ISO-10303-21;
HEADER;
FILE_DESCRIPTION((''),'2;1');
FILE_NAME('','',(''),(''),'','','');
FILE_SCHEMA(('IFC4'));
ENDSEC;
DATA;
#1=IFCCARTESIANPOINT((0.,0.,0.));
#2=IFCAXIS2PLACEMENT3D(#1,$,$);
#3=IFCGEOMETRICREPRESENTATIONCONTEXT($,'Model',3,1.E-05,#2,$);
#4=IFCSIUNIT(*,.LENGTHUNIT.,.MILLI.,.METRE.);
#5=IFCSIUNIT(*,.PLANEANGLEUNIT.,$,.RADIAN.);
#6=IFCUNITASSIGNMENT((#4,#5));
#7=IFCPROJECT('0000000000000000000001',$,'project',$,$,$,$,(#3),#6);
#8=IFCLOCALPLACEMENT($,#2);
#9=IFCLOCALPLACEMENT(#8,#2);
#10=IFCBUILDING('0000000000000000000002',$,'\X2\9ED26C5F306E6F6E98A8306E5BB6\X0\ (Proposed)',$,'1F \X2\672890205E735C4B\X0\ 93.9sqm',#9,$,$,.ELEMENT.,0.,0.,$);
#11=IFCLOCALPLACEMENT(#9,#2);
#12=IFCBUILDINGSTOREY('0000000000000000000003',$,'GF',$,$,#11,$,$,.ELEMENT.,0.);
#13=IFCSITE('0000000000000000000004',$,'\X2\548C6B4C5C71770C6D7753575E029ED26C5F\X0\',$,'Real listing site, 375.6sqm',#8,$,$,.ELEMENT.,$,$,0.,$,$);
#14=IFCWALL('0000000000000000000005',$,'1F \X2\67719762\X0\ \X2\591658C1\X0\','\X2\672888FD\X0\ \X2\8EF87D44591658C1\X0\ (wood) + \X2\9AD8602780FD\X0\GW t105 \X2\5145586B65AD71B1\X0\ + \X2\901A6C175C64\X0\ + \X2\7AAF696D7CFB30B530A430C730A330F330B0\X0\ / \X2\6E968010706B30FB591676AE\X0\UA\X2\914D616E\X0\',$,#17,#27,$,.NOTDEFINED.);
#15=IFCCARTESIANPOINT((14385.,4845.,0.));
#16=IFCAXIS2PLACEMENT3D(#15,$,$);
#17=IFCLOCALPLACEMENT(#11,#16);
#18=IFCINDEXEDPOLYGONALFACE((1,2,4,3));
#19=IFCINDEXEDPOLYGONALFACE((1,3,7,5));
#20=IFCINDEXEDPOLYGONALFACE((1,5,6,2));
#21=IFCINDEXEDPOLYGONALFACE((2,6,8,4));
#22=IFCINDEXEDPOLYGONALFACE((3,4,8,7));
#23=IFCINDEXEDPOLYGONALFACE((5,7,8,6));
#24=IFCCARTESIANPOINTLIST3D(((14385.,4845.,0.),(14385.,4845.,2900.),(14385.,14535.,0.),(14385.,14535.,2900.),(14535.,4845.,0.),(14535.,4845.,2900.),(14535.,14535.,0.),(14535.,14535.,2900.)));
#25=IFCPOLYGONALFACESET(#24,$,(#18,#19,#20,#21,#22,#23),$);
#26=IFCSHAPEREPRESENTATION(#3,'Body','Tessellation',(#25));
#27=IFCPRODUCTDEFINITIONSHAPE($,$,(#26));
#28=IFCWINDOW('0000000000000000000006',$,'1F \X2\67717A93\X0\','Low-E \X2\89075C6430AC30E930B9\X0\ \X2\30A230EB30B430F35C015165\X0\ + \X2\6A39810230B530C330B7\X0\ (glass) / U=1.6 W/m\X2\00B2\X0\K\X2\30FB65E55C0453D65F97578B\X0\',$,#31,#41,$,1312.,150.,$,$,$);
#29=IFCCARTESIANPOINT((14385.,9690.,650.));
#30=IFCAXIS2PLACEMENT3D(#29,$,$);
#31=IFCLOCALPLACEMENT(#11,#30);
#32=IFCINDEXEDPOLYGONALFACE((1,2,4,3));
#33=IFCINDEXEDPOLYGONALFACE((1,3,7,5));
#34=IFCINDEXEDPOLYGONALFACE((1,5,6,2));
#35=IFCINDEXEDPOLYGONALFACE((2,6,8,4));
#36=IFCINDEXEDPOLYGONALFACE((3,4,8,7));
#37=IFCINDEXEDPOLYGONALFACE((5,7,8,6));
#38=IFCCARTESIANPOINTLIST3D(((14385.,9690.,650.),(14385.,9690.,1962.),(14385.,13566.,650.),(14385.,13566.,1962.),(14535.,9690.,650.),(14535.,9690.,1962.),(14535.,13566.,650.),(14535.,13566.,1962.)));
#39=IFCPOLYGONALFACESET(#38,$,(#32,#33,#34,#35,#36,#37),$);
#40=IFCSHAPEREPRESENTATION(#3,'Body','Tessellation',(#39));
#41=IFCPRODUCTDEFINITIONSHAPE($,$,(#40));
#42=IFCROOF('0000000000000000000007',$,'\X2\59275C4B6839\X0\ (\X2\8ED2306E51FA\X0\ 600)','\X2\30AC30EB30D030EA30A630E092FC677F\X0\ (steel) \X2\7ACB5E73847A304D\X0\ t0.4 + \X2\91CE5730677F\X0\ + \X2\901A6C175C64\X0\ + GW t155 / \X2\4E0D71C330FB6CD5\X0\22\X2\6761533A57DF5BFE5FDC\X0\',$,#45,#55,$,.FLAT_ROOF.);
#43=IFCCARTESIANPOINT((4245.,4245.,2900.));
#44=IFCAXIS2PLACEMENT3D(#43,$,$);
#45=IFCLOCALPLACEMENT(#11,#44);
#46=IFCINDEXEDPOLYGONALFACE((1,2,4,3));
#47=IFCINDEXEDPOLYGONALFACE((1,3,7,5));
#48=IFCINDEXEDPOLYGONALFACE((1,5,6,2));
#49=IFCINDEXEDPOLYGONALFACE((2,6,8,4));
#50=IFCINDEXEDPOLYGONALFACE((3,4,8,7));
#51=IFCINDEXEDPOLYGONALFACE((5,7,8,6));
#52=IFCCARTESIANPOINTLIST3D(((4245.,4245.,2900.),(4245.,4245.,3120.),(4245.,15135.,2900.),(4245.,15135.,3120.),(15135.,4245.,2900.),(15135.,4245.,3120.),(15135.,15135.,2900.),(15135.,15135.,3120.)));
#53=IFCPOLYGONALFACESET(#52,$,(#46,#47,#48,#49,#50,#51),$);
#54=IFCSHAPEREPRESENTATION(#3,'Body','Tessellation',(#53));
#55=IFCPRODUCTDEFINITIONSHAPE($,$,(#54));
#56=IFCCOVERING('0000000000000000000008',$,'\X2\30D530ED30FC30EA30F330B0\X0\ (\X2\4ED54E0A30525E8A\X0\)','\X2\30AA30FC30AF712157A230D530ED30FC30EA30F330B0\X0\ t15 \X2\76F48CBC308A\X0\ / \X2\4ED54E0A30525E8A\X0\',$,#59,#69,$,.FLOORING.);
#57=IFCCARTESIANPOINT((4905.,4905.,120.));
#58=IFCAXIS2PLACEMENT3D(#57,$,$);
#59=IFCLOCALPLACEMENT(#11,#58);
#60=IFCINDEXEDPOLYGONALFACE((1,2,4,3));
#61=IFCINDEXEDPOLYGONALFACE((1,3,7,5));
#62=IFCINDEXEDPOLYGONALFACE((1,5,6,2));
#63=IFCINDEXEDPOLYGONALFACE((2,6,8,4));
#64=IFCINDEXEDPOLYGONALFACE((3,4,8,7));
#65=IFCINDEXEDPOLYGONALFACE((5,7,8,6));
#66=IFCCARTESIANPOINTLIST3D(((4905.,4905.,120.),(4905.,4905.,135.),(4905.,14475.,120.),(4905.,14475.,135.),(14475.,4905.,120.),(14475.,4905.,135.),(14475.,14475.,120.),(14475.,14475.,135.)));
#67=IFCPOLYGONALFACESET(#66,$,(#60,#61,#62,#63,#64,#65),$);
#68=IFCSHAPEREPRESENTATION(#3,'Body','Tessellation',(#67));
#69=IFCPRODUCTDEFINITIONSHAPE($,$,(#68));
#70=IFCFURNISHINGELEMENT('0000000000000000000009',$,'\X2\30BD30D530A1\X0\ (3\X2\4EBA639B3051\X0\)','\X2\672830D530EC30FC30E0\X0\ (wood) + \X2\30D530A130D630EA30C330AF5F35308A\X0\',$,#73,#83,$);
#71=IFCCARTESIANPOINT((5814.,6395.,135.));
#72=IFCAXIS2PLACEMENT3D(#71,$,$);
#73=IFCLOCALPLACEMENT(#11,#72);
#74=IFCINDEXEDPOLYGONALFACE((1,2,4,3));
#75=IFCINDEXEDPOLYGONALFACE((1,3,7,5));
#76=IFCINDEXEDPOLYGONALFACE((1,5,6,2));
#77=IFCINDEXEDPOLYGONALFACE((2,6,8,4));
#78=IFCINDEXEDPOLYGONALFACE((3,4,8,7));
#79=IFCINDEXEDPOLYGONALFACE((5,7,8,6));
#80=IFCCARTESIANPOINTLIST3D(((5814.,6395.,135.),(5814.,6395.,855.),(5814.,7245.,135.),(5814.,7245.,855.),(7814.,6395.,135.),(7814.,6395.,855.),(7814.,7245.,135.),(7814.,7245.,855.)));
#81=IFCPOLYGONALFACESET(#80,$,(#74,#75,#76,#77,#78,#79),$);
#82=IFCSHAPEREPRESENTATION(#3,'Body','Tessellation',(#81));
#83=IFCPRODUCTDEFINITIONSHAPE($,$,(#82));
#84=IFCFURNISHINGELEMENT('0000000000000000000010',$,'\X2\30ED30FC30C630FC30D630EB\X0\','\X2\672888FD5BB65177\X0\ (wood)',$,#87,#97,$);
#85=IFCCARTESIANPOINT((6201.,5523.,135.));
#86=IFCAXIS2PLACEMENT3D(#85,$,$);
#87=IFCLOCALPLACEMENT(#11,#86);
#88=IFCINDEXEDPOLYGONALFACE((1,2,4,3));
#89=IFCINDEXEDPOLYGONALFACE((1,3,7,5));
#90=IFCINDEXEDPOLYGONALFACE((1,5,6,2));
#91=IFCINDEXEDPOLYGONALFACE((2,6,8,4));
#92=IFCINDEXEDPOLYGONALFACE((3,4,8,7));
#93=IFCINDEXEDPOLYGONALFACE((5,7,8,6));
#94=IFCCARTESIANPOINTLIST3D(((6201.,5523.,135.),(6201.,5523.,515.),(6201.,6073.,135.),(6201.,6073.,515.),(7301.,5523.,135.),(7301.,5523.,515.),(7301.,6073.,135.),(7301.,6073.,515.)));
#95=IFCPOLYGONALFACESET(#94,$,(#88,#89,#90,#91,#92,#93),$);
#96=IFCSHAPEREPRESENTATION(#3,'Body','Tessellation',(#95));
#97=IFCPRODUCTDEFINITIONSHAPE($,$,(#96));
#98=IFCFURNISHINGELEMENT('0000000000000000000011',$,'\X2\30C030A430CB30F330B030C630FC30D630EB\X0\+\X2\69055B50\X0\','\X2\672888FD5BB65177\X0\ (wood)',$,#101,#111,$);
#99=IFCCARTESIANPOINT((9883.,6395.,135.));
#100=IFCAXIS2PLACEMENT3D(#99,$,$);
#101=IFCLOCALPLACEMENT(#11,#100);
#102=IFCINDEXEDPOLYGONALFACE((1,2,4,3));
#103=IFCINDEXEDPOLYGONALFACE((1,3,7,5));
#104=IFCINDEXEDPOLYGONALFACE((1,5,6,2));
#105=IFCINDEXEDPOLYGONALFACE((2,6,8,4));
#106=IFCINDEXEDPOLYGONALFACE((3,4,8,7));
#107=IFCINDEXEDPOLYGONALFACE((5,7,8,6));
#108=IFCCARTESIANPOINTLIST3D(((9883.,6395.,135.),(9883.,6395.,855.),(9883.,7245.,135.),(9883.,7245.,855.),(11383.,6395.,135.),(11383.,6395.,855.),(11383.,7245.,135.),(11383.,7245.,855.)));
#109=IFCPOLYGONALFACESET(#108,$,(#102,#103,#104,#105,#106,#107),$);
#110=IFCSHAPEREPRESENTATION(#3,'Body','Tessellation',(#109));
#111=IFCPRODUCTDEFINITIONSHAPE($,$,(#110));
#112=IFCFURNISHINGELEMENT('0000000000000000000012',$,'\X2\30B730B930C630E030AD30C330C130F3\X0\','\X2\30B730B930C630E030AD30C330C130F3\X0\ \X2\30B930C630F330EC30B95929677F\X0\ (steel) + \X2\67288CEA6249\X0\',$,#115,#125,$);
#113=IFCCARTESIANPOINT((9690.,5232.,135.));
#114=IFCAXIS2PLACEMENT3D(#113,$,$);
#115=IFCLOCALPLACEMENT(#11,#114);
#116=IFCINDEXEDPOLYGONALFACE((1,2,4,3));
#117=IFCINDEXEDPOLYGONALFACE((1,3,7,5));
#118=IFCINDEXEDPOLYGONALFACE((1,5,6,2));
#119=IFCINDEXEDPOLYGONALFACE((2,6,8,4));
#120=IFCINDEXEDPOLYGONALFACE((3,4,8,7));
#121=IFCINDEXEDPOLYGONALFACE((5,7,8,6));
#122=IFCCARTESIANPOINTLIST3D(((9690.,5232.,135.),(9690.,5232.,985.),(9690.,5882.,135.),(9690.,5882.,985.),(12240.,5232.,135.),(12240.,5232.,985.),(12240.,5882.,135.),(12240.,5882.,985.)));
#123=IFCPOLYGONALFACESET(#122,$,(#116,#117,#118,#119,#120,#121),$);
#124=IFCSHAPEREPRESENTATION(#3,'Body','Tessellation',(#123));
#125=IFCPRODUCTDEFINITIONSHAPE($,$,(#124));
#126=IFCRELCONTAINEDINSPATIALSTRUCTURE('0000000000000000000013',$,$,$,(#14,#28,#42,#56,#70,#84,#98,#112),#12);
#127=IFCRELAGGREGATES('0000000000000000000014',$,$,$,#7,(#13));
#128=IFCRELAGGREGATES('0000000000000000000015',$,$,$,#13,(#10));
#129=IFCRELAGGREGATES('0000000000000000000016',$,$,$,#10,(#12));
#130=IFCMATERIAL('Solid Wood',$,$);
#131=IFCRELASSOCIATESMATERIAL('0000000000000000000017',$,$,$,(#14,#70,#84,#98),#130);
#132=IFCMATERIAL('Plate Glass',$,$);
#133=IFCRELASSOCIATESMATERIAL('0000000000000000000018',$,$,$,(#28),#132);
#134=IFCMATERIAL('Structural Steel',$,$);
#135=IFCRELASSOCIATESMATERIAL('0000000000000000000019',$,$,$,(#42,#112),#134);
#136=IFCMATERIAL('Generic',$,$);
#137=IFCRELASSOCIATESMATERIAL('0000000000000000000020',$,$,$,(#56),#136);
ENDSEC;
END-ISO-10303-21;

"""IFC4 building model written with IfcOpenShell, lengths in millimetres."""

from ifc_helpers import new_model, si_unit, frame, frame_2d, origin, place, context, project, spatial, rectangle, extrude, material, element, fill, save


model = new_model("IFC4")

# Units and contexts
model_context = context("Model", 3, precision=1e-05, world=origin())
ifc_project = project(units=[si_unit("LENGTHUNIT", "METRE", prefix="MILLI"), si_unit("PLANEANGLEUNIT", "RADIAN")], contexts=[model_context])

# Site, building, storey
site_placement = place(None, origin())
site = spatial("IfcSite", under=ifc_project, at=site_placement, Name="和歌山県海南市黒江", ObjectType="Real listing site, 375.6sqm", CompositionType="ELEMENT", RefElevation=0.0)
building_placement = place(site_placement, origin())
building = spatial("IfcBuilding", under=site, at=building_placement, Name="黒江の潮風の家 (Proposed)", ObjectType="1F 木造平屋 93.9sqm", CompositionType="ELEMENT", ElevationOfRefHeight=0.0, ElevationOfTerrain=0.0)
storey_placement = place(building_placement, origin())
storey = spatial("IfcBuildingStorey", under=building, at=storey_placement, Name="GF", CompositionType="ELEMENT", Elevation=0.0)

# Shared definitions
ifc_material_1 = material(Name="Solid Wood")

# Shared definitions
ifc_material_2 = material(Name="Plate Glass")

# Wall, opening, window
wall_1_placement = place(storey_placement, frame((14385.0, 4845.0, 0.0)))
wall_1 = element("IfcWall", 1, at=wall_1_placement, inside=storey, material=ifc_material_1, Name="1F 東面 外壁", Description="木製 軸組外壁 (wood) + 高性能GW t105 充填断熱 + 通気層 + 窯業系サイディング / 準耐火・外皮UA配慮", PredefinedType="NOTDEFINED", context=model_context, shape_type="SweptSolid", body=[
    extrude(rectangle(XDim=150.0, YDim=9690.0, at=frame_2d((75.0, 4845.0))), frame((14385.0, 4845.0, 0.0)), (0.0, 0.0, 1.0), 2900.0),
])
opening_1_placement = place(storey_placement, frame((14385.0, 9690.0, 650.0)))
opening_1 = element("IfcOpeningElement", 2, at=opening_1_placement, cuts=wall_1, PredefinedType="NOTDEFINED", context=model_context, shape_type="SweptSolid", body=[
    extrude(rectangle(XDim=150.0, YDim=3876.0, at=frame_2d((75.0, 1938.0))), frame((14385.0, 9690.0, 650.0)), (0.0, 0.0, 1.0), 1312.0),
])
window_1_placement = place(storey_placement, frame((14385.0, 9690.0, 650.0)))
window_1 = element("IfcWindow", 3, at=window_1_placement, inside=storey, material=ifc_material_2, Name="1F 東窓", Description="Low-E 複層ガラス アルゴン封入 + 樹脂サッシ (glass) / U=1.6 W/m²K・日射取得型", OverallHeight=1312.0, OverallWidth=150.0, context=model_context, shape_type="SweptSolid", body=[
    extrude(rectangle(XDim=150.0, YDim=3876.0, at=frame_2d((75.0, 1938.0))), frame((14385.0, 9690.0, 650.0)), (0.0, 0.0, 1.0), 1312.0),
])
fill(opening_1, window_1)

# Roof
ifc_material_3 = material(Name="Structural Steel")
roof_placement = place(storey_placement, frame((4245.0, 4245.0, 2900.0)))
element("IfcRoof", 4, at=roof_placement, inside=storey, material=ifc_material_3, Name="大屋根 (軒の出 600)", Description="ガルバリウム鋼板 (steel) 立平葺き t0.4 + 野地板 + 通気層 + GW t155 / 不燃・法22条区域対応", PredefinedType="FLAT_ROOF", context=model_context, shape_type="SweptSolid", body=[
    extrude(rectangle(XDim=10890.0, YDim=10890.0, at=frame_2d((5445.0, 5445.0))), frame((4245.0, 4245.0, 2900.0)), (0.0, 0.0, 1.0), 220.0),
])

# Covering
ifc_material_4 = material(Name="Generic")
covering_placement = place(storey_placement, frame((4905.0, 4905.0, 120.0)))
element("IfcCovering", 5, at=covering_placement, inside=storey, material=ifc_material_4, Name="フローリング (仕上げ床)", Description="オーク無垢フローリング t15 直貼り / 仕上げ床", PredefinedType="FLOORING", context=model_context, shape_type="SweptSolid", body=[
    extrude(rectangle(XDim=9570.0, YDim=9570.0, at=frame_2d((4785.0, 4785.0))), frame((4905.0, 4905.0, 120.0)), (0.0, 0.0, 1.0), 15.0),
])

# Furnishing elements
furnishing_1_placement = place(storey_placement, frame((5814.0, 6395.0, 135.0)))
element("IfcFurnishingElement", 6, at=furnishing_1_placement, inside=storey, material=ifc_material_1, Name="ソファ (3人掛け)", Description="木フレーム (wood) + ファブリック張り", context=model_context, shape_type="SweptSolid", body=[
    extrude(rectangle(XDim=2000.0, YDim=850.0, at=frame_2d((1000.0, 425.0))), frame((5814.0, 6395.0, 135.0)), (0.0, 0.0, 1.0), 720.0),
])
furnishing_2_placement = place(storey_placement, frame((6201.0, 5523.0, 135.0)))
element("IfcFurnishingElement", 7, at=furnishing_2_placement, inside=storey, material=ifc_material_1, Name="ローテーブル", Description="木製家具 (wood)", context=model_context, shape_type="SweptSolid", body=[
    extrude(rectangle(XDim=1100.0, YDim=550.0, at=frame_2d((550.0, 275.0))), frame((6201.0, 5523.0, 135.0)), (0.0, 0.0, 1.0), 380.0),
])
furnishing_3_placement = place(storey_placement, frame((9883.0, 6395.0, 135.0)))
element("IfcFurnishingElement", 8, at=furnishing_3_placement, inside=storey, material=ifc_material_1, Name="ダイニングテーブル+椅子", Description="木製家具 (wood)", context=model_context, shape_type="SweptSolid", body=[
    extrude(rectangle(XDim=1500.0, YDim=850.0, at=frame_2d((750.0, 425.0))), frame((9883.0, 6395.0, 135.0)), (0.0, 0.0, 1.0), 720.0),
])
furnishing_4_placement = place(storey_placement, frame((9690.0, 5232.0, 135.0)))
element("IfcFurnishingElement", 9, at=furnishing_4_placement, inside=storey, material=ifc_material_3, Name="システムキッチン", Description="システムキッチン ステンレス天板 (steel) + 木質扉", context=model_context, shape_type="SweptSolid", body=[
    extrude(rectangle(XDim=2550.0, YDim=650.0, at=frame_2d((1275.0, 325.0))), frame((9690.0, 5232.0, 135.0)), (0.0, 0.0, 1.0), 850.0),
])

save(model, "model.ifc")
